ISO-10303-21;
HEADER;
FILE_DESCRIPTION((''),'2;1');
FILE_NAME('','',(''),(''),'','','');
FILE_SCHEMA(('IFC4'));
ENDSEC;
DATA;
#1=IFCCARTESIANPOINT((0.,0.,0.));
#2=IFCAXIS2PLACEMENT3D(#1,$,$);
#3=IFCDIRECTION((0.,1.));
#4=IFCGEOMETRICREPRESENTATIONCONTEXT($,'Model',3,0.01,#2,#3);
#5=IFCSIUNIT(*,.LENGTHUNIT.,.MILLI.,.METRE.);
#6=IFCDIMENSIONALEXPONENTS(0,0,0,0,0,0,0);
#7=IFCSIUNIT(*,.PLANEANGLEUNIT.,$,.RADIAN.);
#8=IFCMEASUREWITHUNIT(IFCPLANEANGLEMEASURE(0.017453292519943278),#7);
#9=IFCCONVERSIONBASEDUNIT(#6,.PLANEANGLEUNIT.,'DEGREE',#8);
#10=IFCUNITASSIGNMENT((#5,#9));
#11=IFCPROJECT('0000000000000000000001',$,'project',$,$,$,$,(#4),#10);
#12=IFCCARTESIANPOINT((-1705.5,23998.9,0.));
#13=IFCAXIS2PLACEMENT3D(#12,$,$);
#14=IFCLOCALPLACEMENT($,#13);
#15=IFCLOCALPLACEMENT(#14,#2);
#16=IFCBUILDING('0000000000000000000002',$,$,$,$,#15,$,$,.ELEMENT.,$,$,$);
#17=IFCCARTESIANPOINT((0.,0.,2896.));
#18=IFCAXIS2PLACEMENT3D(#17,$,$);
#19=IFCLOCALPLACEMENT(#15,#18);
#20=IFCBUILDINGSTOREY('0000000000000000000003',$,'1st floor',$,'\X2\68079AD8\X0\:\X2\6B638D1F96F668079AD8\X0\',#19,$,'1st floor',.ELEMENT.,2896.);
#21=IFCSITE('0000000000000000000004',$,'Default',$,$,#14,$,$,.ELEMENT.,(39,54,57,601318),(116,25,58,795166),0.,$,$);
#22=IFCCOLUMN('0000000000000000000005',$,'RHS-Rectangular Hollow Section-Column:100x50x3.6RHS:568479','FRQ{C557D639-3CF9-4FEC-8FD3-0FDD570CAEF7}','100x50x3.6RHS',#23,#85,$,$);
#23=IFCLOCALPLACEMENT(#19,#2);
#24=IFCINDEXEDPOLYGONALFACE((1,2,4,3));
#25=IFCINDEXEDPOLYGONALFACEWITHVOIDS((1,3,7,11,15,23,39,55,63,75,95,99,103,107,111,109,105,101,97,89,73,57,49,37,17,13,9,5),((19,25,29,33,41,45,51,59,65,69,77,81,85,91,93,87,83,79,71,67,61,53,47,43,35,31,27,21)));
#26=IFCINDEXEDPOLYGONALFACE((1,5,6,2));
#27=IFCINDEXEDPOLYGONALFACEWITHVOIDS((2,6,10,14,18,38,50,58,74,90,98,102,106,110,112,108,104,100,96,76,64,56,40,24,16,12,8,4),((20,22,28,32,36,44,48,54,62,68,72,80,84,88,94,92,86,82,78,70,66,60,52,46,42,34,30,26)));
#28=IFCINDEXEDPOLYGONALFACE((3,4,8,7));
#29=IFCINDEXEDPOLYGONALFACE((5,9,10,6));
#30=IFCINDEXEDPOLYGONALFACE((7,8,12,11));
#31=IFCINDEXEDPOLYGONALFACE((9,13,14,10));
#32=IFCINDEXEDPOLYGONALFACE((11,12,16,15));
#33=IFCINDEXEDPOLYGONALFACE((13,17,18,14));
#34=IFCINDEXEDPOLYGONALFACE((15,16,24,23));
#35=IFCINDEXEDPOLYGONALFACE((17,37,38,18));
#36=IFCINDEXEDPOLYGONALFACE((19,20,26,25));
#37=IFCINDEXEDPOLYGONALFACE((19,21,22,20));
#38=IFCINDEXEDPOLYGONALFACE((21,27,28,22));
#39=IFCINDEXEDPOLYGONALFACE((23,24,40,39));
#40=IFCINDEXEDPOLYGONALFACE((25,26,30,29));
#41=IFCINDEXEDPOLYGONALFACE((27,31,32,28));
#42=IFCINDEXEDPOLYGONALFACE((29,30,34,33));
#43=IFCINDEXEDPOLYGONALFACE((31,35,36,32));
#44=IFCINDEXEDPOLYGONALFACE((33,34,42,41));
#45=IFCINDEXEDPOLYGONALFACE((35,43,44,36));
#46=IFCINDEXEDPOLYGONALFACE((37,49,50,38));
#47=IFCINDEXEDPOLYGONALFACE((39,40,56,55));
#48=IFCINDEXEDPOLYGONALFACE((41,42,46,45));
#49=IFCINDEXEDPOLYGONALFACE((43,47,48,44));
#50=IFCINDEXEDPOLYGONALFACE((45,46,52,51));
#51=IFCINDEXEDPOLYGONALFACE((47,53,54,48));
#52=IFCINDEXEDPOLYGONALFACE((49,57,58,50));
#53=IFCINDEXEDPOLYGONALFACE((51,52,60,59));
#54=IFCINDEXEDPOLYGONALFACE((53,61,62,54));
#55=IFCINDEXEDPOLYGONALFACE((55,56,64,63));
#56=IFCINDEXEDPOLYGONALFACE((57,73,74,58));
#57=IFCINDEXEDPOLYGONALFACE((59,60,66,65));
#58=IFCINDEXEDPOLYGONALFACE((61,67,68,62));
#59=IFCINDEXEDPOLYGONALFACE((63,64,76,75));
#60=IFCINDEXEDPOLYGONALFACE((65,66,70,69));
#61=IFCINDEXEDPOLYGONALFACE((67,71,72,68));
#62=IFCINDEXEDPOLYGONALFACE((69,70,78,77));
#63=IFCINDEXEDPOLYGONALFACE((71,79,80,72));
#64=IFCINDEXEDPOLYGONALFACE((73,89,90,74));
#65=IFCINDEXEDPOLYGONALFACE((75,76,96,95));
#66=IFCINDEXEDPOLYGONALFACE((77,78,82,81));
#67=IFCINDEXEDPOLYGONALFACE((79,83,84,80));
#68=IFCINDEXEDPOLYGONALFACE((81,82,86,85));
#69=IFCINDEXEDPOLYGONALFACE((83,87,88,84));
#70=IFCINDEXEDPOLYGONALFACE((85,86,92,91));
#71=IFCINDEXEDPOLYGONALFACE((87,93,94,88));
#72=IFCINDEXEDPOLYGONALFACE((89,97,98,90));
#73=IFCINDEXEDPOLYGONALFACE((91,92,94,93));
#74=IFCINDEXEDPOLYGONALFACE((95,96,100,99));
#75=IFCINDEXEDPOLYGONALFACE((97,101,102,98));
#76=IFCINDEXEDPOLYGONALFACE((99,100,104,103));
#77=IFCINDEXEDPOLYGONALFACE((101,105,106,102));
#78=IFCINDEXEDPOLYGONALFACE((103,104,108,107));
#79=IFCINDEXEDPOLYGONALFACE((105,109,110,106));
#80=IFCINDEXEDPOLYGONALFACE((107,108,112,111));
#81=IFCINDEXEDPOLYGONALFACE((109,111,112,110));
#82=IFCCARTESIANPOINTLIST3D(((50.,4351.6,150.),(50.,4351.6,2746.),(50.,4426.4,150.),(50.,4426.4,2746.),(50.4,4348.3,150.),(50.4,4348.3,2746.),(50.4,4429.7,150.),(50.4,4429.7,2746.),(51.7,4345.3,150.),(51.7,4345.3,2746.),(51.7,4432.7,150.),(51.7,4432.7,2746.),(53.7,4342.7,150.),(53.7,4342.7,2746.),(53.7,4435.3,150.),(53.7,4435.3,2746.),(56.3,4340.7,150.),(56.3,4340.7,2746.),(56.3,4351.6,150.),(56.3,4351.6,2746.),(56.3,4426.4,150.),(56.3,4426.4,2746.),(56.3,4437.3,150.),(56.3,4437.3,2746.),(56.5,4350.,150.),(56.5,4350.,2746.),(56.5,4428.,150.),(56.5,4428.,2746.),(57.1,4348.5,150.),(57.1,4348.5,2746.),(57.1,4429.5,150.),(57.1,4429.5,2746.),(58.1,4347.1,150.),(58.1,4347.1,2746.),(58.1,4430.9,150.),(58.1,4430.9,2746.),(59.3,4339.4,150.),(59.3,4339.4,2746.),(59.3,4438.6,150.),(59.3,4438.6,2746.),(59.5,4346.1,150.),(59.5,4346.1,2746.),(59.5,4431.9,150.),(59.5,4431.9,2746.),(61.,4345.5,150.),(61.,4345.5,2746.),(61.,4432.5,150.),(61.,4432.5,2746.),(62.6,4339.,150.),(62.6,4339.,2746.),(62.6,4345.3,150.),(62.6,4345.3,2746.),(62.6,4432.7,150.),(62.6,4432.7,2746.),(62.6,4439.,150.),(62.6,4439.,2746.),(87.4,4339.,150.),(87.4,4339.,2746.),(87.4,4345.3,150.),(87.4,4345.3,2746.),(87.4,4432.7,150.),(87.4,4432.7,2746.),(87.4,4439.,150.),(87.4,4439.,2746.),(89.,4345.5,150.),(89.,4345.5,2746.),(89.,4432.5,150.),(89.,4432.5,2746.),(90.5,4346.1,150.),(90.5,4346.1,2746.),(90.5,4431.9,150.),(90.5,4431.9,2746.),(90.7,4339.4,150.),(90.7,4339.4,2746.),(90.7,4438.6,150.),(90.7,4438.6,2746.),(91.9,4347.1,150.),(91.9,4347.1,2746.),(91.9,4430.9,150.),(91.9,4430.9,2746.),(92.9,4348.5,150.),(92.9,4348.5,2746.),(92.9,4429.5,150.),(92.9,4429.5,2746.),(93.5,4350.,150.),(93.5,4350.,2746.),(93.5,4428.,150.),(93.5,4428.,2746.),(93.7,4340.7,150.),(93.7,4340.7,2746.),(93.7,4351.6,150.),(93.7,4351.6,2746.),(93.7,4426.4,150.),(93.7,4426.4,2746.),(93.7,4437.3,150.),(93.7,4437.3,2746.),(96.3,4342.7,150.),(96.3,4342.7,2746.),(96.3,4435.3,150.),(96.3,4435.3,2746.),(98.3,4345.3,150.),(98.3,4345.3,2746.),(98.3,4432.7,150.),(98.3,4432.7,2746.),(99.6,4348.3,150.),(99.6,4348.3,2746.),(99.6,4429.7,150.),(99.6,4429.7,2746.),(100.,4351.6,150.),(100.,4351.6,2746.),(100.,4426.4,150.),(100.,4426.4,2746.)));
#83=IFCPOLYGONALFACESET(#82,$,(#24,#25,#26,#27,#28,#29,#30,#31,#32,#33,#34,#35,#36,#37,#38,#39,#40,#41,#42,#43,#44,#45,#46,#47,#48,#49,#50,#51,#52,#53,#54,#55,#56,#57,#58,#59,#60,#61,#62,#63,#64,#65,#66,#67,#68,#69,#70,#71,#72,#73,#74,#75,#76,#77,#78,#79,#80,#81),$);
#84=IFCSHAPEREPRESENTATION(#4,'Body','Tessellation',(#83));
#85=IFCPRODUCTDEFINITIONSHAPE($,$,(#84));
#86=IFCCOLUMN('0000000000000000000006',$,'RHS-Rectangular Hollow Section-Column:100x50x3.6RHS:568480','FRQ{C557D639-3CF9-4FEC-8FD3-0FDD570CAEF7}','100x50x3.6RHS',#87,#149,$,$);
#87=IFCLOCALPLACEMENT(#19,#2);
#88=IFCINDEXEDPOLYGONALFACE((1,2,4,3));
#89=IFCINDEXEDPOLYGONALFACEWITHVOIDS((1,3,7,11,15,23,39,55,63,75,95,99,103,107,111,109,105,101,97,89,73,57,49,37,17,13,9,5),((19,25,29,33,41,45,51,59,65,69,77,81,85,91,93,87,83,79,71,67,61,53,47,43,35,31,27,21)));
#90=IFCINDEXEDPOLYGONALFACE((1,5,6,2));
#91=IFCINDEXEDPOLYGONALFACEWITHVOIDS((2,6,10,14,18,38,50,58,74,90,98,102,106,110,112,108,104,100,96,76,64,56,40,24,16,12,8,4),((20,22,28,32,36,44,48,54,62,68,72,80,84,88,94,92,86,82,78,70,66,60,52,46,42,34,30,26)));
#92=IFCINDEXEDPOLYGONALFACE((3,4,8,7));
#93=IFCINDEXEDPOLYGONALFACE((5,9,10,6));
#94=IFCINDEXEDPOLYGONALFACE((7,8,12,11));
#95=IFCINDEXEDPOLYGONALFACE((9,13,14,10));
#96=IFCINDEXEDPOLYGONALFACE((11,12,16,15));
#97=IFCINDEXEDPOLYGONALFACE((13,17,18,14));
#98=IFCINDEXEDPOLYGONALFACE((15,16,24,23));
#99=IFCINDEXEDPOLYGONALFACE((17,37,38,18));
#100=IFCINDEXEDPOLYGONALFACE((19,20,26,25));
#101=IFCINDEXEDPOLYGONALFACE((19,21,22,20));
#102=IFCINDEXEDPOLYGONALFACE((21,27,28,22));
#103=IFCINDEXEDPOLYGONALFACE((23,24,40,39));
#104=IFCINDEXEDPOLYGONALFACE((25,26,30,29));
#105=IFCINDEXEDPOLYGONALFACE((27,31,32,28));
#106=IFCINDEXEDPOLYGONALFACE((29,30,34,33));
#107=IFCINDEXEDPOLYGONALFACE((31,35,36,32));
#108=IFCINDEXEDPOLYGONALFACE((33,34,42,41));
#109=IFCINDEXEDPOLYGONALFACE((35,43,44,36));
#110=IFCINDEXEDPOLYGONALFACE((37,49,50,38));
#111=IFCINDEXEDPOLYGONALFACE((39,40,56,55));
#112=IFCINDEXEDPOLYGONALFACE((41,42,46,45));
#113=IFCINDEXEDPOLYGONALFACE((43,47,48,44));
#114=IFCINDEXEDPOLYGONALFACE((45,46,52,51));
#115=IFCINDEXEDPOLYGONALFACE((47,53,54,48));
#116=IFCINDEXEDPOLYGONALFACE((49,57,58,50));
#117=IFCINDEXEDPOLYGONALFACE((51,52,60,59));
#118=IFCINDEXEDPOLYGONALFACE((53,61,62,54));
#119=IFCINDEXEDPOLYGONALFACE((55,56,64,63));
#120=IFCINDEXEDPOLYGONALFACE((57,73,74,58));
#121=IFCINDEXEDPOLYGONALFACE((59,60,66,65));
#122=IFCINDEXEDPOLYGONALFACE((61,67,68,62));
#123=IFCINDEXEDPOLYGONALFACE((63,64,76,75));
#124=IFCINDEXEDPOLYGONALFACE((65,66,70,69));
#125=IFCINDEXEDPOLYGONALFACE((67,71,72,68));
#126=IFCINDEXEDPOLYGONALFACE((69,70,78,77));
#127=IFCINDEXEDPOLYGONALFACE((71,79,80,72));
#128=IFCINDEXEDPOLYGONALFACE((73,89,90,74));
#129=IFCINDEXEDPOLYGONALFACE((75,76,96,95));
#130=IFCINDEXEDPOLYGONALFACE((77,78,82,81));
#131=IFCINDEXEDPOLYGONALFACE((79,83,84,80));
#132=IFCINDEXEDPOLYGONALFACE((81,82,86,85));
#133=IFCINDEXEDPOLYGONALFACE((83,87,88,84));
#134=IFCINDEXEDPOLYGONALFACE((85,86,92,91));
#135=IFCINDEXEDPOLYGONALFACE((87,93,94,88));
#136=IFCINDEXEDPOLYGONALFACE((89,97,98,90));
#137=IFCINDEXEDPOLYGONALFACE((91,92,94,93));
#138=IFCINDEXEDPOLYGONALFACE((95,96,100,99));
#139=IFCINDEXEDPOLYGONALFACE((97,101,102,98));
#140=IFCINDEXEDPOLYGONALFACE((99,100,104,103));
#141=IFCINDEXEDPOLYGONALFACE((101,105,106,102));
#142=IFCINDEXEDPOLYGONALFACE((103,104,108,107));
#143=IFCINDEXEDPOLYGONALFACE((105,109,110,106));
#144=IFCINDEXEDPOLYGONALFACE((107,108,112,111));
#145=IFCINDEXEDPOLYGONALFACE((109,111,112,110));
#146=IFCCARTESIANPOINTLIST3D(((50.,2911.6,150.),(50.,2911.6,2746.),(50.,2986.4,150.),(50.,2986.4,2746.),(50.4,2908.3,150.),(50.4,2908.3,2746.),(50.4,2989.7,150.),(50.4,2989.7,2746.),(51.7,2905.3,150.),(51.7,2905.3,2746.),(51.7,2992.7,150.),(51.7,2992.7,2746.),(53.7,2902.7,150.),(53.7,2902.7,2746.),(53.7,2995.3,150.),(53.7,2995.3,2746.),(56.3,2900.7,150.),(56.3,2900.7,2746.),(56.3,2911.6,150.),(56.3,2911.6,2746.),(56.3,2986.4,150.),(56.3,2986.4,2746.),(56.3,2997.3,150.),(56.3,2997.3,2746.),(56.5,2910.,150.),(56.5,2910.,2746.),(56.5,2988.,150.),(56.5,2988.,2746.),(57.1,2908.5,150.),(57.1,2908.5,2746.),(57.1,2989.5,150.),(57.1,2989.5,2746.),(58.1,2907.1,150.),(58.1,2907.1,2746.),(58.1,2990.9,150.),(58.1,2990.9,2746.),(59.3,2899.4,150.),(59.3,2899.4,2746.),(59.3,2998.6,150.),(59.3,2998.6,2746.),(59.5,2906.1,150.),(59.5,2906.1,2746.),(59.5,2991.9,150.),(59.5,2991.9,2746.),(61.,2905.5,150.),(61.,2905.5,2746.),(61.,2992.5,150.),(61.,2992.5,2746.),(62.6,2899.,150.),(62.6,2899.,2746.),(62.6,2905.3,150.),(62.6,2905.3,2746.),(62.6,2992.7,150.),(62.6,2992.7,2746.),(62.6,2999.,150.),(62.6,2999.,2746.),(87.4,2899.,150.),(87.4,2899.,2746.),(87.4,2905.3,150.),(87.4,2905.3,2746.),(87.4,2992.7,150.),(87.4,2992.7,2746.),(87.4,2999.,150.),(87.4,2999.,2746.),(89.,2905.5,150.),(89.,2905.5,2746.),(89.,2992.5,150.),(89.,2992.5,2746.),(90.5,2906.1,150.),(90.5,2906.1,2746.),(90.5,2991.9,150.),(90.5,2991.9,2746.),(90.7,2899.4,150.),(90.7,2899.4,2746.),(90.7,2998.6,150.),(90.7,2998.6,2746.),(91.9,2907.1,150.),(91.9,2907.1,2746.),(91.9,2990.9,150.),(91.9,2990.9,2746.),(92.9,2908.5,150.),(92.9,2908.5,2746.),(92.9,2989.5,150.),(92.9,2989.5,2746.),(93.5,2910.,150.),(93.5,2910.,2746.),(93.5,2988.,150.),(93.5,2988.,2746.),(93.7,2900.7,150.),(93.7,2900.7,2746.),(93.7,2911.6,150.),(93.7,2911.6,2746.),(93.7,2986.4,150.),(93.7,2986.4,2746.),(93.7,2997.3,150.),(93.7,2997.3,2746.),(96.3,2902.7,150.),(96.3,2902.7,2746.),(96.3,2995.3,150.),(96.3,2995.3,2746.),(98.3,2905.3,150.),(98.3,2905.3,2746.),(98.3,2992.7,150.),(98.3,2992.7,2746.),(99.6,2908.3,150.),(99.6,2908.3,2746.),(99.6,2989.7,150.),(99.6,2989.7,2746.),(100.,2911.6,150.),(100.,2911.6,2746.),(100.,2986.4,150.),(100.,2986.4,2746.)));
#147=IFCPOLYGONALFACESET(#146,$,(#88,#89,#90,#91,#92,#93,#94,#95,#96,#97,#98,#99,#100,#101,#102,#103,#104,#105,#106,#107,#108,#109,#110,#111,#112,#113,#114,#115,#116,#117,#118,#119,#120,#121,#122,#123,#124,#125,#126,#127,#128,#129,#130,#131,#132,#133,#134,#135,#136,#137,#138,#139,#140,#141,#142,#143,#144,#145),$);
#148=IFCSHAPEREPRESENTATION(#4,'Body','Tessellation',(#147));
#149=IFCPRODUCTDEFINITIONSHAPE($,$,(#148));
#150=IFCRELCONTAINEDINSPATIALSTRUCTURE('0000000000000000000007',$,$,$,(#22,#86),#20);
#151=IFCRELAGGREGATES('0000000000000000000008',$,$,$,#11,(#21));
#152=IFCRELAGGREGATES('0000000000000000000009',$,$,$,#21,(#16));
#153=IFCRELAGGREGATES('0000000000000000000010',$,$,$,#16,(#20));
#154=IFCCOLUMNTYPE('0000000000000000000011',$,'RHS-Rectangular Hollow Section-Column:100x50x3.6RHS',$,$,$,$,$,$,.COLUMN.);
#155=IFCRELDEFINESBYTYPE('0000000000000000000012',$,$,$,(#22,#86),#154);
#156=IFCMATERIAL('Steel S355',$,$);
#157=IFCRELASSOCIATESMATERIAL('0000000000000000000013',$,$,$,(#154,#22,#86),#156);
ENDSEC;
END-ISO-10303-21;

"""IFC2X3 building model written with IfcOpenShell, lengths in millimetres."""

from ifc_helpers import new_model, entity, si_unit, converted_unit, point, direction, frame, frame_2d, origin, origin_2d, place, context, project, spatial, circle_curve, line_curve, trimmed, segment, composite_curve, hollow_rectangle, outline, extrude, clip, halfspace, material, type_object, element, save


model = new_model("IFC2X3")

# Units and contexts
model_context = context("Model", 3, precision=0.01, world=origin(), true_north=direction((0.0, 1.0)))
ifc_project = project(units=[si_unit("LENGTHUNIT", "METRE", prefix="MILLI"), converted_unit("PLANEANGLEUNIT", "DEGREE", entity("IfcPlaneAngleMeasure", 0.017453292519943278), si_unit("PLANEANGLEUNIT", "RADIAN"), dimensions=[0, 0, 0, 0, 0, 0, 0])], contexts=[model_context])

# Site, building, storey
site_placement = place(None, frame((-1705.5, 23998.9, 0.0)))
site = spatial("IfcSite", under=ifc_project, at=site_placement, Name="Default", CompositionType="ELEMENT", RefLatitude=(39, 54, 57, 601318), RefLongitude=(116, 25, 58, 795166), RefElevation=0.0)
building_placement = place(site_placement, origin())
building = spatial("IfcBuilding", under=site, at=building_placement, CompositionType="ELEMENT")
storey_placement = place(building_placement, frame((0.0, 0.0, 2896.0)))
storey = spatial("IfcBuildingStorey", under=building, at=storey_placement, Name="1st floor", ObjectType="标高:正负零标高", LongName="1st floor", CompositionType="ELEMENT", Elevation=2896.0)

# Columns, openings
ifc_material_1 = material(Name="Steel S355")
column_type_1 = type_object("IfcColumnType", Name="RHS-Rectangular Hollow Section-Column:100x50x3.6RHS", PredefinedType="COLUMN", material=ifc_material_1)
column_1_placement = place(storey_placement, frame((75.0, 4389.0, 2876.9)))
column_1 = element("IfcColumn", 1, at=column_1_placement, inside=storey, type_object=column_type_1, material=ifc_material_1, Name="RHS-Rectangular Hollow Section-Column:100x50x3.6RHS:568479", Description="FRQ{C557D639-3CF9-4FEC-8FD3-0FDD570CAEF7}", ObjectType="100x50x3.6RHS", context=model_context, shape_type="Clipping", body=[
    clip(clip(extrude(hollow_rectangle(XDim=50.0, YDim=100.0, WallThickness=6.3, InnerFilletRadius=6.3, OuterFilletRadius=12.6, at=origin_2d()), origin(), (0.0, 0.0, -1.0), 2782.8), halfspace(frame((-75.0, -4389.0, -2726.9), z_axis=(0.0, 0.0, 1.0), x_axis=(1.0, 0.0, 0.0)), True)), halfspace(frame((-75.0, -4389.0, -55.9), z_axis=(0.0, 0.0, -1.0), x_axis=(-1.0, 0.0, 0.0)), True)),
])
opening_1_placement = place(column_1_placement, frame((0.0, -150.1, -130.9), z_axis=(0.0, 1.0, 0.0), x_axis=(-1.0, 0.0, 0.0)))
element("IfcOpeningElement", 2, at=opening_1_placement, cuts=column_1, ObjectType="Opening", context=model_context, shape_type="SweptSolid", body=[
    extrude(outline(composite_curve([segment(trimmed(circle_curve(frame_2d((43.0, 32.0), x_axis=(1.0, 0.0)), 32.0), [point((43.0, 0.0))], [point((75.0, 32.0))], True, "CARTESIAN"), True, "CONTINUOUS"), segment(trimmed(line_curve((75.0, 32.0), (0.0, 1.0), 86.0), [point((75.0, 32.0))], [point((75.0, 118.0))], True, "CARTESIAN"), True, "CONTINUOUS"), segment(trimmed(circle_curve(frame_2d((43.0, 118.0), x_axis=(1.0, 0.0)), 32.0), [point((75.0, 118.0))], [point((43.0, 150.0))], True, "CARTESIAN"), True, "CONTINUOUS"), segment(trimmed(line_curve((43.0, 150.0), (-1.0, 0.0), 86.0), [point((43.0, 150.0))], [point((-43.0, 150.0))], True, "CARTESIAN"), True, "CONTINUOUS"), segment(trimmed(circle_curve(frame_2d((-43.0, 118.0), x_axis=(1.0, 0.0)), 32.0), [point((-43.0, 150.0))], [point((-75.0, 118.0))], True, "CARTESIAN"), True, "CONTINUOUS"), segment(trimmed(line_curve((-75.0, 118.0), (0.0, -1.0), 86.0), [point((-75.0, 118.0))], [point((-75.0, 32.0))], True, "CARTESIAN"), True, "CONTINUOUS"), segment(trimmed(circle_curve(frame_2d((-43.0, 32.0), x_axis=(1.0, 0.0)), 32.0), [point((-75.0, 32.0))], [point((-43.0, 0.0))], True, "CARTESIAN"), True, "CONTINUOUS"), segment(trimmed(line_curve((-43.0, 0.0), (1.0, 0.0), 86.0), [point((-43.0, 0.0))], [point((43.0, 0.0))], True, "CARTESIAN"), True, "CONTINUOUS")], self_intersect="UNKNOWN")), origin(), (0.0, 0.0, 1.0), 300.2),
])
column_2_placement = place(storey_placement, frame((75.0, 2949.0, 2876.9)))
column_2 = element("IfcColumn", 3, at=column_2_placement, inside=storey, type_object=column_type_1, material=ifc_material_1, Name="RHS-Rectangular Hollow Section-Column:100x50x3.6RHS:568480", Description="FRQ{C557D639-3CF9-4FEC-8FD3-0FDD570CAEF7}", ObjectType="100x50x3.6RHS", context=model_context, shape_type="Clipping", body=[
    clip(clip(extrude(hollow_rectangle(XDim=50.0, YDim=100.0, WallThickness=6.3, InnerFilletRadius=6.3, OuterFilletRadius=12.6, at=origin_2d()), origin(), (0.0, 0.0, -1.0), 2782.8), halfspace(frame((-75.0, -2949.0, -55.9), z_axis=(0.0, 0.0, -1.0), x_axis=(-1.0, 0.0, 0.0)), True)), halfspace(frame((-75.0, -2949.0, -2726.9), z_axis=(0.0, 0.0, 1.0), x_axis=(1.0, 0.0, 0.0)), True)),
])
opening_2_placement = place(column_2_placement, frame((0.0, -150.1, -130.9), z_axis=(0.0, 1.0, 0.0), x_axis=(-1.0, 0.0, 0.0)))
element("IfcOpeningElement", 4, at=opening_2_placement, cuts=column_2, ObjectType="Opening", context=model_context, shape_type="SweptSolid", body=[
    extrude(outline(composite_curve([segment(trimmed(circle_curve(frame_2d((43.0, 32.0), x_axis=(1.0, 0.0)), 32.0), [point((43.0, 0.0))], [point((75.0, 32.0))], True, "CARTESIAN"), True, "CONTINUOUS"), segment(trimmed(line_curve((75.0, 32.0), (0.0, 1.0), 86.0), [point((75.0, 32.0))], [point((75.0, 118.0))], True, "CARTESIAN"), True, "CONTINUOUS"), segment(trimmed(circle_curve(frame_2d((43.0, 118.0), x_axis=(1.0, 0.0)), 32.0), [point((75.0, 118.0))], [point((43.0, 150.0))], True, "CARTESIAN"), True, "CONTINUOUS"), segment(trimmed(line_curve((43.0, 150.0), (-1.0, 0.0), 86.0), [point((43.0, 150.0))], [point((-43.0, 150.0))], True, "CARTESIAN"), True, "CONTINUOUS"), segment(trimmed(circle_curve(frame_2d((-43.0, 118.0), x_axis=(1.0, 0.0)), 32.0), [point((-43.0, 150.0))], [point((-75.0, 118.0))], True, "CARTESIAN"), True, "CONTINUOUS"), segment(trimmed(line_curve((-75.0, 118.0), (0.0, -1.0), 86.0), [point((-75.0, 118.0))], [point((-75.0, 32.0))], True, "CARTESIAN"), True, "CONTINUOUS"), segment(trimmed(circle_curve(frame_2d((-43.0, 32.0), x_axis=(1.0, 0.0)), 32.0), [point((-75.0, 32.0))], [point((-43.0, 0.0))], True, "CARTESIAN"), True, "CONTINUOUS"), segment(trimmed(line_curve((-43.0, 0.0), (1.0, 0.0), 86.0), [point((-43.0, 0.0))], [point((43.0, 0.0))], True, "CARTESIAN"), True, "CONTINUOUS")], self_intersect="UNKNOWN")), origin(), (0.0, 0.0, 1.0), 300.2),
])

save(model, "model.ifc")
